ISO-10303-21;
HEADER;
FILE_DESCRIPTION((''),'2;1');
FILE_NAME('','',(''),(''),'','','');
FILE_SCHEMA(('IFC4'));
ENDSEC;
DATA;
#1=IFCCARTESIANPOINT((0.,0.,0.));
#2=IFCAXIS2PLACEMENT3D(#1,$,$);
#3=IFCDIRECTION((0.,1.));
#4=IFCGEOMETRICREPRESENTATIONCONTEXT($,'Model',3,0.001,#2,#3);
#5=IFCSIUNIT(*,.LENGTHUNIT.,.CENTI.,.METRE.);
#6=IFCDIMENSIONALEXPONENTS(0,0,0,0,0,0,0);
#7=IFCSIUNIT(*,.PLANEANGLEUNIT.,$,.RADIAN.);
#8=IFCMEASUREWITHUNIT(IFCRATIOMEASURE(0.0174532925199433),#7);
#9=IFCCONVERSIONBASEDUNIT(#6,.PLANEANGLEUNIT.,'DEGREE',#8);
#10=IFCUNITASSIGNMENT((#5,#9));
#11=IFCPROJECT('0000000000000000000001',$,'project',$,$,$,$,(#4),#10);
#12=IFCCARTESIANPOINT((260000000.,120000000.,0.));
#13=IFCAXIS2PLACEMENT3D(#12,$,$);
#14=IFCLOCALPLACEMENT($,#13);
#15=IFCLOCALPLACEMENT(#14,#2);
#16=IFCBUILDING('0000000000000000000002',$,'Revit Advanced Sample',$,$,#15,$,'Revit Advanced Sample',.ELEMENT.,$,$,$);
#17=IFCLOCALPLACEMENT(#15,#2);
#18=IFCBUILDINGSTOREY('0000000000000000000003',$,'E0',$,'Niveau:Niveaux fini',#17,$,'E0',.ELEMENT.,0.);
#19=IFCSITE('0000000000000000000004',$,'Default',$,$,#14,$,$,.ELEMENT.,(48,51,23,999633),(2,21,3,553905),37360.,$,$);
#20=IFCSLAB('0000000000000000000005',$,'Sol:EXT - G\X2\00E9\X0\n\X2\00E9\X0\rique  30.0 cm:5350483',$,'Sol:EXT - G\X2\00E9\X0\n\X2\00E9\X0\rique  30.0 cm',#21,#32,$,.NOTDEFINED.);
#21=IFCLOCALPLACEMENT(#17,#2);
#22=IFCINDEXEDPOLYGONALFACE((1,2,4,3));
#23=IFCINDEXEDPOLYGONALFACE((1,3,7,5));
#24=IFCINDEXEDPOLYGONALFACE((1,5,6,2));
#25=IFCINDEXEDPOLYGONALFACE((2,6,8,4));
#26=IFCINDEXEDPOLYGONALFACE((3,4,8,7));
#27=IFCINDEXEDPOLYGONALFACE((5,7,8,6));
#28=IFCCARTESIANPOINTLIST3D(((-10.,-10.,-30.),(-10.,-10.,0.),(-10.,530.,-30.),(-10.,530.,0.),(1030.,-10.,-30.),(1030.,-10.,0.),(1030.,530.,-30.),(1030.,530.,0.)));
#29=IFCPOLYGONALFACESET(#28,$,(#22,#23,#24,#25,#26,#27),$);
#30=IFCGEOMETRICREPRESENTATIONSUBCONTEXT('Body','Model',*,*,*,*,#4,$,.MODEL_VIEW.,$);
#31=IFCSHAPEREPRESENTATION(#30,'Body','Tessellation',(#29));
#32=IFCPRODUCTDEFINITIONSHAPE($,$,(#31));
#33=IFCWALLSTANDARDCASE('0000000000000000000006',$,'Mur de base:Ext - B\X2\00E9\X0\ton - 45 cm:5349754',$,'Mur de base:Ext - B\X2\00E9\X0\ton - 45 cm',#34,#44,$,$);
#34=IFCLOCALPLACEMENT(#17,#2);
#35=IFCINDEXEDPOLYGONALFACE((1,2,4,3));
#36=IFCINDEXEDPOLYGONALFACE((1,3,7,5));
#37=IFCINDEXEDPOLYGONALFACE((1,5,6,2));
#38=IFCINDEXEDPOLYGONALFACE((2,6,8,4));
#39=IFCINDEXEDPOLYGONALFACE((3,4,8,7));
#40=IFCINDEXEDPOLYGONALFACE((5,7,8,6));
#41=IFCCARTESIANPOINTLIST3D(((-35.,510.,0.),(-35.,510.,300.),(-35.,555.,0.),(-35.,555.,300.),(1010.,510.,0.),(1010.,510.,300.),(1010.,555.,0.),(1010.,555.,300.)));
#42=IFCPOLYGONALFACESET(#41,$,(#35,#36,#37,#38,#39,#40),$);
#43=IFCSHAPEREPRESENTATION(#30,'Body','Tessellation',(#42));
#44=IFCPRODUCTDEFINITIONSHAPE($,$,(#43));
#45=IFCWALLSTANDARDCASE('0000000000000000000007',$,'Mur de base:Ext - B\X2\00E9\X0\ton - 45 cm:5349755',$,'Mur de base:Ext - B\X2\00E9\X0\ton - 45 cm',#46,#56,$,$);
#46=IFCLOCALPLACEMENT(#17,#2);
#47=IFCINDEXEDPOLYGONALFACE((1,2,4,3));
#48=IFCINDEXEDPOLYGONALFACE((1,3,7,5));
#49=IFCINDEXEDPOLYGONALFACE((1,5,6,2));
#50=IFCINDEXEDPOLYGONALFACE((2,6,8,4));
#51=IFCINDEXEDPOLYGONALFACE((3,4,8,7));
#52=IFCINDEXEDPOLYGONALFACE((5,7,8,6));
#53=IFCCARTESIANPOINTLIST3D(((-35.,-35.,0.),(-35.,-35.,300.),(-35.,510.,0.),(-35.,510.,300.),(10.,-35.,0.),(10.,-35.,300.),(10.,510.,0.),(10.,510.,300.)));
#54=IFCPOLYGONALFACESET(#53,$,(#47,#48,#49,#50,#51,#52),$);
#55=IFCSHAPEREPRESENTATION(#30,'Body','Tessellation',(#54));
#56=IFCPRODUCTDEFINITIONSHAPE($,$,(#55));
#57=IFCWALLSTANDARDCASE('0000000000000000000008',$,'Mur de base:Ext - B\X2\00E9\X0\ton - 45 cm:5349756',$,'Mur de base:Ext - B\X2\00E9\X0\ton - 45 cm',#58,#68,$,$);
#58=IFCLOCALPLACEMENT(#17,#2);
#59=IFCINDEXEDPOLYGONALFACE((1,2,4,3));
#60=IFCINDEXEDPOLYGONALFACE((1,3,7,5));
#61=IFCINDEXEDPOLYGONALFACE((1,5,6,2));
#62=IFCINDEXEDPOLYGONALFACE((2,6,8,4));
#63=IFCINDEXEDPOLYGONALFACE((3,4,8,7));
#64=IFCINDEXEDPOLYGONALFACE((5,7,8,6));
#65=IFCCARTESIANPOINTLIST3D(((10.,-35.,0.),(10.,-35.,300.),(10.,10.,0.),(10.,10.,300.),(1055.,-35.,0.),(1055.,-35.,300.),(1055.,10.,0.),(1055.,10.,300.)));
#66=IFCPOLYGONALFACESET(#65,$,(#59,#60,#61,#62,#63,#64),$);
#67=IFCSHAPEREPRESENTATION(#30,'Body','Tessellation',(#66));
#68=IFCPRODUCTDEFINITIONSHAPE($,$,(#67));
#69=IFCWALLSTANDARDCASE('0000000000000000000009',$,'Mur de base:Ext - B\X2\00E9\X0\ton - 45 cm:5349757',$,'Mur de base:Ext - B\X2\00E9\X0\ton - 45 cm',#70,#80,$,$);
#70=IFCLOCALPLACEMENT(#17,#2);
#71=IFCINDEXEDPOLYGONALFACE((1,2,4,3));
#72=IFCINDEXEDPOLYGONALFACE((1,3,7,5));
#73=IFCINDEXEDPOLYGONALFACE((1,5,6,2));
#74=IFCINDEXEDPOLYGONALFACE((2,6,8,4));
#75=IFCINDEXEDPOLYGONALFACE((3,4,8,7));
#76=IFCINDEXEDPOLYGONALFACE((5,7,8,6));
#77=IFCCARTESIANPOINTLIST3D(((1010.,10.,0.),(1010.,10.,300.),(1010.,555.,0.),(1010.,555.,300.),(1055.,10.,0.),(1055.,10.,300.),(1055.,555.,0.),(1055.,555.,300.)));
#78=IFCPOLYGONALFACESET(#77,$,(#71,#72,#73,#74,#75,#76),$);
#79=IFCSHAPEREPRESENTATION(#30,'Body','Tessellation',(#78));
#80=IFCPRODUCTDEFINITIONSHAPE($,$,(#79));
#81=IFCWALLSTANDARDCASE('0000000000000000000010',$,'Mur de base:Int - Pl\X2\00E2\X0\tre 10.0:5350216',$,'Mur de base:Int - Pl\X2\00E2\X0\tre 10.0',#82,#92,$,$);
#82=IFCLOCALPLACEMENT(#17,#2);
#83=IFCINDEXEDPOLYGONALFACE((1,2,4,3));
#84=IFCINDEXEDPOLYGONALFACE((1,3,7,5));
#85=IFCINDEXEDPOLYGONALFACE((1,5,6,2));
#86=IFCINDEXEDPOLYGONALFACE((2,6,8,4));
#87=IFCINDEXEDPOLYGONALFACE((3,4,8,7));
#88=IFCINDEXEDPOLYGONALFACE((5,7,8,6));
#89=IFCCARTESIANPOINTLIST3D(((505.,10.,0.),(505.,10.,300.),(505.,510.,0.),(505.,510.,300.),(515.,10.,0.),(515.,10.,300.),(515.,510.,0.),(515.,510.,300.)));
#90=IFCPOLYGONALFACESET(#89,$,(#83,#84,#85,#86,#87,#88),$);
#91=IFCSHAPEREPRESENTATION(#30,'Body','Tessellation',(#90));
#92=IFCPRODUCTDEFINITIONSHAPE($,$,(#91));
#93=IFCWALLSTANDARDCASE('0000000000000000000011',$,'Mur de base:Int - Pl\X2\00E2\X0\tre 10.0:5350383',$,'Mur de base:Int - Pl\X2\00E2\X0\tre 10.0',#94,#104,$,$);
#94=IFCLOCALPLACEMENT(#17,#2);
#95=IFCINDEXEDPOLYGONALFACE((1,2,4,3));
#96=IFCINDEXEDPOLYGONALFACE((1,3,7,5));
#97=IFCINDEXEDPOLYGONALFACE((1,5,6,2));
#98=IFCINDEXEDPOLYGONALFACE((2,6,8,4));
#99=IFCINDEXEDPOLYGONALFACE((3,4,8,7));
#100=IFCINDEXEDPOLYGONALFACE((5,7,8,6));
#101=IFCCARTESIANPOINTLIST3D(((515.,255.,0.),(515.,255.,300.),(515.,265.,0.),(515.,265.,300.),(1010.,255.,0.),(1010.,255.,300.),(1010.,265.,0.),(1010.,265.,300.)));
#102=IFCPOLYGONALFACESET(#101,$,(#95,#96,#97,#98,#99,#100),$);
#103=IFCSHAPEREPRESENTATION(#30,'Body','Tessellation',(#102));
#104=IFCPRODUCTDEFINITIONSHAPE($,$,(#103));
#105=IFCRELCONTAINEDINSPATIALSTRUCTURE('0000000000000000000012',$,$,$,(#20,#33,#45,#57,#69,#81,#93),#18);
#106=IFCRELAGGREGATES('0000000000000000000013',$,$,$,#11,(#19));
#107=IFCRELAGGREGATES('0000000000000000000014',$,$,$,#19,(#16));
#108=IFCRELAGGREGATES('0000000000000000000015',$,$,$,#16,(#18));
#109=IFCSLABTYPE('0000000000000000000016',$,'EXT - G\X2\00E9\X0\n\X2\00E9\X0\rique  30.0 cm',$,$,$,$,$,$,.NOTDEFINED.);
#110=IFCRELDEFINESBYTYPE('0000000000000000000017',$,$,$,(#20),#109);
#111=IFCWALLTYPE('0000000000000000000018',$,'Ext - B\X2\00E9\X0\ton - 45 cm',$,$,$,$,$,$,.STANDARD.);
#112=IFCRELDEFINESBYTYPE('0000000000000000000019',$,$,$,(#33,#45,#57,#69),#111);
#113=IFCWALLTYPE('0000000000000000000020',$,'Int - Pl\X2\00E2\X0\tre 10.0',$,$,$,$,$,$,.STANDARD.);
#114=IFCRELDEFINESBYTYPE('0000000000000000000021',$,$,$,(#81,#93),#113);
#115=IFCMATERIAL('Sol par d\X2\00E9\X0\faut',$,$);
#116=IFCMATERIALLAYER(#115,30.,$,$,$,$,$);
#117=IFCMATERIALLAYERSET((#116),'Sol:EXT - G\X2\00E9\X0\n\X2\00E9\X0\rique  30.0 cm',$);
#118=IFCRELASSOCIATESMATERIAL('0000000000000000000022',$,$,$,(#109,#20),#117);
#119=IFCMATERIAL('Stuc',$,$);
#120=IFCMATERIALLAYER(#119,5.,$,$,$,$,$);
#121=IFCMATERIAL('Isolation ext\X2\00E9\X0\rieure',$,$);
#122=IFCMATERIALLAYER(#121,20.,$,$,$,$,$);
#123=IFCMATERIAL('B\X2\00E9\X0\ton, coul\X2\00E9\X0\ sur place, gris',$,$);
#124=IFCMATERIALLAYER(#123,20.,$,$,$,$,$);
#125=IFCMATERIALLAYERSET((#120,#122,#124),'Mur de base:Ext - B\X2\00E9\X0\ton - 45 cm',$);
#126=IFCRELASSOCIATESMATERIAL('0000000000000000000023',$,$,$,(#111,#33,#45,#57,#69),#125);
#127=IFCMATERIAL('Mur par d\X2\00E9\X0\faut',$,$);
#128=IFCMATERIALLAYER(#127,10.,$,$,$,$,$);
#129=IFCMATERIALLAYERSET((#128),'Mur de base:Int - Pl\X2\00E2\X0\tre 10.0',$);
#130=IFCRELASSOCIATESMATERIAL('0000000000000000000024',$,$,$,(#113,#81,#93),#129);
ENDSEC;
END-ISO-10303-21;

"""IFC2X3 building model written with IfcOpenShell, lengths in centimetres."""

from ifc_helpers import new_model, entity, si_unit, converted_unit, direction, frame, frame_2d, origin, place, context, subcontext, project, spatial, rectangle, extrude, material, layer, layer_set, layer_usage, type_object, element, save


model = new_model("IFC2X3")

# Units and contexts
model_context = context("Model", 3, precision=0.001, world=origin(), true_north=direction((0.0, 1.0)))
body_context = subcontext(model_context, "Body", "Model", "MODEL_VIEW")
ifc_project = project(units=[si_unit("LENGTHUNIT", "METRE", prefix="CENTI"), converted_unit("PLANEANGLEUNIT", "DEGREE", entity("IfcRatioMeasure", 0.0174532925199433), si_unit("PLANEANGLEUNIT", "RADIAN"), dimensions=[0, 0, 0, 0, 0, 0, 0])], contexts=[model_context])

# Site, building, storey
site_placement = place(None, frame((260000000.0, 120000000.0, 0.0)))
site = spatial("IfcSite", under=ifc_project, at=site_placement, Name="Default", CompositionType="ELEMENT", RefLatitude=(48, 51, 23, 999633), RefLongitude=(2, 21, 3, 553905), RefElevation=37360.0)
building_placement = place(site_placement, origin())
building = spatial("IfcBuilding", under=site, at=building_placement, Name="Revit Advanced Sample", LongName="Revit Advanced Sample", CompositionType="ELEMENT")
storey_placement = place(building_placement, origin())
storey = spatial("IfcBuildingStorey", under=building, at=storey_placement, Name="E0", ObjectType="Niveau:Niveaux fini", LongName="E0", CompositionType="ELEMENT", Elevation=0.0)

# Slab
ifc_material_1 = material(Name="Sol par défaut")
ifc_layer_1 = layer(ifc_material_1, 30.0)
ifc_layer_set_1 = layer_set([ifc_layer_1], Name="Sol:EXT - Générique  30.0 cm")
ifc_layer_usage_1 = layer_usage(ifc_layer_set_1, "AXIS3", "POSITIVE", 0.0)
slab_type = type_object("IfcSlabType", Name="EXT - Générique  30.0 cm", PredefinedType="NOTDEFINED", material=ifc_layer_set_1)
slab_placement = place(storey_placement, origin())
element("IfcSlab", 1, at=slab_placement, inside=storey, type_object=slab_type, material=ifc_layer_usage_1, Name="Sol:EXT - Générique  30.0 cm:5350483", ObjectType="Sol:EXT - Générique  30.0 cm", PredefinedType="NOTDEFINED", context=body_context, shape_type="SweptSolid", body=[
    extrude(rectangle(XDim=540.0, YDim=1040.0, at=frame_2d((0.0, 0.0), x_axis=(1.0, 0.0))), frame((510.0, 260.0, 0.0), z_axis=(0.0, 0.0, -1.0), x_axis=(0.0, 1.0, 0.0)), (0.0, 0.0, 1.0), 30.0),
])

# Walls
ifc_material_2 = material(Name="Stuc")
ifc_layer_2 = layer(ifc_material_2, 5.0)
ifc_material_3 = material(Name="Isolation extérieure")
ifc_layer_3 = layer(ifc_material_3, 20.0)
ifc_material_4 = material(Name="Béton, coulé sur place, gris")
ifc_layer_4 = layer(ifc_material_4, 20.0)
ifc_layer_set_2 = layer_set([ifc_layer_2, ifc_layer_3, ifc_layer_4], Name="Mur de base:Ext - Béton - 45 cm")
ifc_layer_usage_2 = layer_usage(ifc_layer_set_2, "AXIS2", "NEGATIVE", 22.5)
wall_type_1 = type_object("IfcWallType", Name="Ext - Béton - 45 cm", PredefinedType="STANDARD", material=ifc_layer_set_2)
wall_1_placement = place(storey_placement, frame((-35.0, 532.5, 0.0)))
element("IfcWallStandardCase", 2, at=wall_1_placement, inside=storey, type_object=wall_type_1, material=ifc_layer_usage_2, Name="Mur de base:Ext - Béton - 45 cm:5349754", ObjectType="Mur de base:Ext - Béton - 45 cm", context=body_context, shape_type="SweptSolid", body=[
    extrude(rectangle(XDim=1045.0, YDim=45.0, at=frame_2d((522.5, 0.0), x_axis=(-1.0, 0.0))), origin(), (0.0, 0.0, 1.0), 300.0),
])
ifc_layer_usage_3 = layer_usage(ifc_layer_set_2, "AXIS2", "NEGATIVE", 22.5)
wall_2_placement = place(storey_placement, frame((-12.5, -35.0, 0.0), z_axis=(0.0, 0.0, 1.0), x_axis=(0.0, 1.0, 0.0)))
element("IfcWallStandardCase", 3, at=wall_2_placement, inside=storey, type_object=wall_type_1, material=ifc_layer_usage_3, Name="Mur de base:Ext - Béton - 45 cm:5349755", ObjectType="Mur de base:Ext - Béton - 45 cm", context=body_context, shape_type="SweptSolid", body=[
    extrude(rectangle(XDim=545.0, YDim=45.0, at=frame_2d((272.5, 0.0), x_axis=(-1.0, 0.0))), origin(), (0.0, 0.0, 1.0), 300.0),
])
ifc_layer_usage_4 = layer_usage(ifc_layer_set_2, "AXIS2", "NEGATIVE", 22.5)
wall_3_placement = place(storey_placement, frame((1055.0, -12.5, 0.0), z_axis=(0.0, 0.0, 1.0), x_axis=(-1.0, 0.0, 0.0)))
element("IfcWallStandardCase", 4, at=wall_3_placement, inside=storey, type_object=wall_type_1, material=ifc_layer_usage_4, Name="Mur de base:Ext - Béton - 45 cm:5349756", ObjectType="Mur de base:Ext - Béton - 45 cm", context=body_context, shape_type="SweptSolid", body=[
    extrude(rectangle(XDim=1045.0, YDim=45.0, at=frame_2d((522.5, 0.0), x_axis=(-1.0, 0.0))), origin(), (0.0, 0.0, 1.0), 300.0),
])
ifc_layer_usage_5 = layer_usage(ifc_layer_set_2, "AXIS2", "NEGATIVE", 22.5)
wall_4_placement = place(storey_placement, frame((1032.5, 555.0, 0.0), z_axis=(0.0, 0.0, 1.0), x_axis=(0.0, -1.0, 0.0)))
element("IfcWallStandardCase", 5, at=wall_4_placement, inside=storey, type_object=wall_type_1, material=ifc_layer_usage_5, Name="Mur de base:Ext - Béton - 45 cm:5349757", ObjectType="Mur de base:Ext - Béton - 45 cm", context=body_context, shape_type="SweptSolid", body=[
    extrude(rectangle(XDim=545.0, YDim=45.0, at=frame_2d((272.5, 0.0), x_axis=(-1.0, 0.0))), origin(), (0.0, 0.0, 1.0), 300.0),
])
ifc_material_5 = material(Name="Mur par défaut")
ifc_layer_5 = layer(ifc_material_5, 10.0)
ifc_layer_set_3 = layer_set([ifc_layer_5], Name="Mur de base:Int - Plâtre 10.0")
ifc_layer_usage_6 = layer_usage(ifc_layer_set_3, "AXIS2", "NEGATIVE", 5.0)
wall_type_2 = type_object("IfcWallType", Name="Int - Plâtre 10.0", PredefinedType="STANDARD", material=ifc_layer_set_3)
wall_5_placement = place(storey_placement, frame((510.0, 510.0, 0.0), z_axis=(0.0, 0.0, 1.0), x_axis=(0.0, -1.0, 0.0)))
element("IfcWallStandardCase", 6, at=wall_5_placement, inside=storey, type_object=wall_type_2, material=ifc_layer_usage_6, Name="Mur de base:Int - Plâtre 10.0:5350216", ObjectType="Mur de base:Int - Plâtre 10.0", context=body_context, shape_type="SweptSolid", body=[
    extrude(rectangle(XDim=500.0, YDim=10.0, at=frame_2d((250.0, 0.0), x_axis=(-1.0, 0.0))), origin(), (0.0, 0.0, 1.0), 300.0),
])
ifc_layer_usage_7 = layer_usage(ifc_layer_set_3, "AXIS2", "NEGATIVE", 5.0)
wall_6_placement = place(storey_placement, frame((515.0, 260.0, 0.0)))
element("IfcWallStandardCase", 7, at=wall_6_placement, inside=storey, type_object=wall_type_2, material=ifc_layer_usage_7, Name="Mur de base:Int - Plâtre 10.0:5350383", ObjectType="Mur de base:Int - Plâtre 10.0", context=body_context, shape_type="SweptSolid", body=[
    extrude(rectangle(XDim=495.0, YDim=10.0, at=frame_2d((247.5, 0.0), x_axis=(-1.0, 0.0))), origin(), (0.0, 0.0, 1.0), 300.0),
])

save(model, "model.ifc")
